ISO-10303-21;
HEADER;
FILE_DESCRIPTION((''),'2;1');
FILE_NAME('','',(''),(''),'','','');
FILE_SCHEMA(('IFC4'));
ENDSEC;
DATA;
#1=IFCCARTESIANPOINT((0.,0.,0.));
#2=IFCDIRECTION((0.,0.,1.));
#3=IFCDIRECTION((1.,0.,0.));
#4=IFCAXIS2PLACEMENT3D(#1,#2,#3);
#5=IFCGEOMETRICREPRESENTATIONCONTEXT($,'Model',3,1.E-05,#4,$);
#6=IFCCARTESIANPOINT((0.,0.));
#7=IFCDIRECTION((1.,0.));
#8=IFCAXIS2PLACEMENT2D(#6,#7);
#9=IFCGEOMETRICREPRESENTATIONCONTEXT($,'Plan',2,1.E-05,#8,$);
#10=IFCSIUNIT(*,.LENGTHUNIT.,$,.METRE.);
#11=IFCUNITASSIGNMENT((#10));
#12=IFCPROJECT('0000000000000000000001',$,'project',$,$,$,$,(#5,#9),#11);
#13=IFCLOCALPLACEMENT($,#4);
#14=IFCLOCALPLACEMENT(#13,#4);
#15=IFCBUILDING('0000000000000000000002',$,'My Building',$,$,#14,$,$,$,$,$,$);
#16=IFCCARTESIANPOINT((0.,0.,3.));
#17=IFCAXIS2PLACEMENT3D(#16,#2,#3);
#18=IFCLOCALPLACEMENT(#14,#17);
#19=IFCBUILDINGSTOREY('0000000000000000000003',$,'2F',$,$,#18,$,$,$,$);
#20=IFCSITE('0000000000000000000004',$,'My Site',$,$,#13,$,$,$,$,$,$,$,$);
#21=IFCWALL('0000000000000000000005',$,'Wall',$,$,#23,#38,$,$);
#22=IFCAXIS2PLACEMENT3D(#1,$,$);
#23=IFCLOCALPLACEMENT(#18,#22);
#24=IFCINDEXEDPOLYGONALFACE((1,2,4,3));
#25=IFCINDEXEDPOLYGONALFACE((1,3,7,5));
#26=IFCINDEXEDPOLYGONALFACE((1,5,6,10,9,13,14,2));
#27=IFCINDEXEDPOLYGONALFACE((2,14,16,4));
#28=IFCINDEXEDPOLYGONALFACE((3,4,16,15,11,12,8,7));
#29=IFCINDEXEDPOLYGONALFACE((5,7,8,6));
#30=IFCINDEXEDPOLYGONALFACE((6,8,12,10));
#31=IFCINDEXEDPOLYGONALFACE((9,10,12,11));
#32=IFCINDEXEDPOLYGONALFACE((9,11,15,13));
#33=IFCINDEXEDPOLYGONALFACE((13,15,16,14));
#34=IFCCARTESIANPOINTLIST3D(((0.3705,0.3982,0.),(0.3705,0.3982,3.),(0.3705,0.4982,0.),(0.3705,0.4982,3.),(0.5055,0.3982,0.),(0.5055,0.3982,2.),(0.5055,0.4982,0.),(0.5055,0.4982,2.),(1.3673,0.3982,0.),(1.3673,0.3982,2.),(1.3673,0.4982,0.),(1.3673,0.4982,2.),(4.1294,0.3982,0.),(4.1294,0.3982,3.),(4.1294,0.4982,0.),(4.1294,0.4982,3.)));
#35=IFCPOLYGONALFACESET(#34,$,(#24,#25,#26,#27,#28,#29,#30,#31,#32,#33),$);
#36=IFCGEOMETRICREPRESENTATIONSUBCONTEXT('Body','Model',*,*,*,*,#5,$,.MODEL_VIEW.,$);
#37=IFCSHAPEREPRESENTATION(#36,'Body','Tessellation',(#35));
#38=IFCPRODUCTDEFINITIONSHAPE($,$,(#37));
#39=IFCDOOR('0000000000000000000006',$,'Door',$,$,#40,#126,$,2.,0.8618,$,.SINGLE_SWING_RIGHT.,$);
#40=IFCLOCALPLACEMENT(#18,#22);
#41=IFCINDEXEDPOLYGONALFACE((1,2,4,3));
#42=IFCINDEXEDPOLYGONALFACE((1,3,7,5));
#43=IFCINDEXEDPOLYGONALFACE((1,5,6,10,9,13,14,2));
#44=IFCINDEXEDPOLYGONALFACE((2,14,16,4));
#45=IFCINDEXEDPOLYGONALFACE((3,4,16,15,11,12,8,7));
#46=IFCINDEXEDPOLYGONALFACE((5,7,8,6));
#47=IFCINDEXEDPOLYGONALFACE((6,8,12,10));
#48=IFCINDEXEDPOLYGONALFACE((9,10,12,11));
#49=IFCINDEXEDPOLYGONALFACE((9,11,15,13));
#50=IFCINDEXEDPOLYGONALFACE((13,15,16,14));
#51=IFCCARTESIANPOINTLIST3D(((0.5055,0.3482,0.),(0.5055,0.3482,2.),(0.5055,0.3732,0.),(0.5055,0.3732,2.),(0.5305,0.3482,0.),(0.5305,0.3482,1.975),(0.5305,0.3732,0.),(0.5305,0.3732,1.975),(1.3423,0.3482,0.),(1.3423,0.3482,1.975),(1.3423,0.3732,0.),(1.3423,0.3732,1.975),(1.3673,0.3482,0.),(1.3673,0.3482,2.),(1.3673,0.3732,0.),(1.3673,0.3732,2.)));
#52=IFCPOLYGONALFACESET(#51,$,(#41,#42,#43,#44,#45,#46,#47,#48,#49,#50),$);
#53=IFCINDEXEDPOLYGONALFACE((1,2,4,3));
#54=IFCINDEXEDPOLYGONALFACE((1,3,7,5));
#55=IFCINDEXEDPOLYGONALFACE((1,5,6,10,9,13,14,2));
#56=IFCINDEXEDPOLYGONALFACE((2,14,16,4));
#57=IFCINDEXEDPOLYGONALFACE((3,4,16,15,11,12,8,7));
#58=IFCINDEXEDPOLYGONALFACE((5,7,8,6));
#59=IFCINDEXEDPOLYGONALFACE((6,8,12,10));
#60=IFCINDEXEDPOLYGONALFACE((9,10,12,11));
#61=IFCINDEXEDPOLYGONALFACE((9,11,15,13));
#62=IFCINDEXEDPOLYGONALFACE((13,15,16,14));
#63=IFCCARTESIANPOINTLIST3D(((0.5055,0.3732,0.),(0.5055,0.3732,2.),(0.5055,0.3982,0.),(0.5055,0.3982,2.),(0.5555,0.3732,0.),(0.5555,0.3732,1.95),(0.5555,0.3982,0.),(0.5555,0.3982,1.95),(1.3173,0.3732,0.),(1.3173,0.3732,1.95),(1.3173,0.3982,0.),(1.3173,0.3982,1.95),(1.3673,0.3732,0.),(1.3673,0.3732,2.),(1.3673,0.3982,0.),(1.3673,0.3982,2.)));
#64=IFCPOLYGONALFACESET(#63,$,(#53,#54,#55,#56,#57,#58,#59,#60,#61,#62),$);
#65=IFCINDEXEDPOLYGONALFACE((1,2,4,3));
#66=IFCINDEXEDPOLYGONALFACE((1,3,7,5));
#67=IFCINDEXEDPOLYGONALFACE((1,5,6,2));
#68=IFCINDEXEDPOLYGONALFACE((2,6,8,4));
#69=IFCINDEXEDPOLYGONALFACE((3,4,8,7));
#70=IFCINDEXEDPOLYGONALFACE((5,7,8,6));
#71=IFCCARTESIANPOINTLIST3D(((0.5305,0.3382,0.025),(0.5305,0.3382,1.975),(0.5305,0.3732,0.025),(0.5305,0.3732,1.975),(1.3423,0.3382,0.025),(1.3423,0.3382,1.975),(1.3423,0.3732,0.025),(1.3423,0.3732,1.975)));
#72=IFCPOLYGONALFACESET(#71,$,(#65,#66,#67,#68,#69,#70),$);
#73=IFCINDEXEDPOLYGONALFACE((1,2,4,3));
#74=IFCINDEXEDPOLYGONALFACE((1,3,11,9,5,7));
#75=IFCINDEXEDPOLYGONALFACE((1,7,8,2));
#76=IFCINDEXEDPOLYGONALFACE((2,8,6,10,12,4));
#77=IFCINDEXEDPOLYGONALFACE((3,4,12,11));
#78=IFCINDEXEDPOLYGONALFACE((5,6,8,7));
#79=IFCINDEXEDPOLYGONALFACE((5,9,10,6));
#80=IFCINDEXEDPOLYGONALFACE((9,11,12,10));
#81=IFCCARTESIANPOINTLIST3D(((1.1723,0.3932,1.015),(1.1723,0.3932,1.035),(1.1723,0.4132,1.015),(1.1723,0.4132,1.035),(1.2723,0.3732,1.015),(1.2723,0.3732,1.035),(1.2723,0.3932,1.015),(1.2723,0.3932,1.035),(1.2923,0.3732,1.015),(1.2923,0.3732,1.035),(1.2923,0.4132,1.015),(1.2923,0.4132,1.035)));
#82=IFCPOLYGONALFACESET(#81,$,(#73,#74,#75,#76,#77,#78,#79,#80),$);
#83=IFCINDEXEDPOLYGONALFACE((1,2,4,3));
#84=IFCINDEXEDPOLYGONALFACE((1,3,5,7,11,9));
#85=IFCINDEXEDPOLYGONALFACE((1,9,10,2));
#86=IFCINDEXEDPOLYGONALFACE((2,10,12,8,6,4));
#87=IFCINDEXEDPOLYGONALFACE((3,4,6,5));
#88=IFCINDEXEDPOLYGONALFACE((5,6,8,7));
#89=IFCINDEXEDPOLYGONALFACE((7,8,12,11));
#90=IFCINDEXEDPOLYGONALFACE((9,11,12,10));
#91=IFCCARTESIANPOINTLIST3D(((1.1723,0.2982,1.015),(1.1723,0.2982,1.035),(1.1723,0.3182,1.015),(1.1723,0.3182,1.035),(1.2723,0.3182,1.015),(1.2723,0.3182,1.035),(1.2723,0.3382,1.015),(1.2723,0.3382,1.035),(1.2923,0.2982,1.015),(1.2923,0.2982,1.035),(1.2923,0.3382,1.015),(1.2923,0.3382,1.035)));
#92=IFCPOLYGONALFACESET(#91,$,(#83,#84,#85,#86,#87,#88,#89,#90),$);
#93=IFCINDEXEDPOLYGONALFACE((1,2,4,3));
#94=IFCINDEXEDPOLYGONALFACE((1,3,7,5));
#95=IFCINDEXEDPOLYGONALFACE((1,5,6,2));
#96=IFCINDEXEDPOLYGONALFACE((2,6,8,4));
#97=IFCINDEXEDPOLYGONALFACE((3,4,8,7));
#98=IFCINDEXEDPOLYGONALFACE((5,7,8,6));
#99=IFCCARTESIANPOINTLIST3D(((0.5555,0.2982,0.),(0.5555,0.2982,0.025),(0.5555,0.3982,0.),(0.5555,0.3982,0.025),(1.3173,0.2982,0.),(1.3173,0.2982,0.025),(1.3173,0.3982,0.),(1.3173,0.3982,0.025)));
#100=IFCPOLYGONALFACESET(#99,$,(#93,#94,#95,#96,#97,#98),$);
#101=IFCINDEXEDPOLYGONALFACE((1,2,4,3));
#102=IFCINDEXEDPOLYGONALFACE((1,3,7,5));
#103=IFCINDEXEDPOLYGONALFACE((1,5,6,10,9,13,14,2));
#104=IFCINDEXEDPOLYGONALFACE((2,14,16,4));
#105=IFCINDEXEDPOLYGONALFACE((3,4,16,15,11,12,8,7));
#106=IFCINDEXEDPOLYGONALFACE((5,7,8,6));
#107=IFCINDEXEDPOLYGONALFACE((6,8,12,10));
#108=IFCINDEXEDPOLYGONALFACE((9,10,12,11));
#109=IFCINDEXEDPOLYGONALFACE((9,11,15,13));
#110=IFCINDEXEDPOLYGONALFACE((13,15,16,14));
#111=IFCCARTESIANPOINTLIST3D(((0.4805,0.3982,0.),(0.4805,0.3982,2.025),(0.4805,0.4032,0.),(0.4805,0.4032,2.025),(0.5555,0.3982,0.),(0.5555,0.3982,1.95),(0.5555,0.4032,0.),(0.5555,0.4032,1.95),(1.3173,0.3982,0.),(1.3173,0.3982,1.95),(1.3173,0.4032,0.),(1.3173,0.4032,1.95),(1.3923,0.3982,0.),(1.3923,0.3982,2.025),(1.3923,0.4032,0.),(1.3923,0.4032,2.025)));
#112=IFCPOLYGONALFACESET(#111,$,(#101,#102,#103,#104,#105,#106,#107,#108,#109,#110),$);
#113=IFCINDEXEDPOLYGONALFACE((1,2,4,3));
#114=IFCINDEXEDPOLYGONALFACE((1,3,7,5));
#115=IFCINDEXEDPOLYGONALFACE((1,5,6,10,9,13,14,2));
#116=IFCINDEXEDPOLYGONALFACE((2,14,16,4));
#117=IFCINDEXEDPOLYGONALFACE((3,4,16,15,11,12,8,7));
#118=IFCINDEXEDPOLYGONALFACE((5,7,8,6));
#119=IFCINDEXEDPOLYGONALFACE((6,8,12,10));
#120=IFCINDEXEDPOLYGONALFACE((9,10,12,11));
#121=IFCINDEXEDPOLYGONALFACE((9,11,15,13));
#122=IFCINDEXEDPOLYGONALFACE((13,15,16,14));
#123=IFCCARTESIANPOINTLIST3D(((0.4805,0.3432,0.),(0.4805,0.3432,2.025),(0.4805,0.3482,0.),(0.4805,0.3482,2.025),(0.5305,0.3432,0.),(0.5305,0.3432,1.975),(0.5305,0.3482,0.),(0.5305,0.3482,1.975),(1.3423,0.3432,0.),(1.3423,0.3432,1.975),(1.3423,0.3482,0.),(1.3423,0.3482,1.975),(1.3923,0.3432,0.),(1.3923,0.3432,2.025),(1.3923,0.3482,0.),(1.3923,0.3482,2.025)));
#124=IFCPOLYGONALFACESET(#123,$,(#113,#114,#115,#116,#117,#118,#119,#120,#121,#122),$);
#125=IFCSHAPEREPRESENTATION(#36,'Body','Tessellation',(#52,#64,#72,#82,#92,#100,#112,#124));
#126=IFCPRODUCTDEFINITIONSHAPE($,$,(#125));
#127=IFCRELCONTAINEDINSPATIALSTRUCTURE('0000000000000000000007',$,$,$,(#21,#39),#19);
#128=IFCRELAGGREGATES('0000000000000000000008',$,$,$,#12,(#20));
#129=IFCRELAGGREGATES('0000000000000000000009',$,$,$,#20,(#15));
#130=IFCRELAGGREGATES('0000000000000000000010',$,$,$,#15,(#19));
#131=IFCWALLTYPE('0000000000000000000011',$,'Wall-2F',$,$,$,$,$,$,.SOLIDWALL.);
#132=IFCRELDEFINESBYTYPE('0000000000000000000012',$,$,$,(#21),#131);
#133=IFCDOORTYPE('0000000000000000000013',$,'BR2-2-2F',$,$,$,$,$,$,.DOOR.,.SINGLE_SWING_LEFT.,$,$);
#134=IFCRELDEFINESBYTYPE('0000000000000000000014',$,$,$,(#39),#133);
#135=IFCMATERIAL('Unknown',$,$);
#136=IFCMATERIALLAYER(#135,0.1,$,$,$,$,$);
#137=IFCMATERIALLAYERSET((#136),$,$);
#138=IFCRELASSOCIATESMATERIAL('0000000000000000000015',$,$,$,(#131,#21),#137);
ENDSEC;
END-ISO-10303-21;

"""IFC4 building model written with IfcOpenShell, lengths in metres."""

from ifc_helpers import new_model, entity, si_unit, frame, origin_with_axes, origin_2d_with_axis, place, context, subcontext, project, spatial, line, indexed_curve, outline, extrude, shape, source, transform, mapped, material, layer, layer_set, layer_usage, type_object, type_shapes, element, fill, save


model = new_model("IFC4")

# Units and contexts
model_context = context("Model", 3, precision=1e-05, world=origin_with_axes())
plan_context = context("Plan", 2, precision=1e-05, world=origin_2d_with_axis())
body_context_1 = subcontext(model_context, "Body", "Model", "MODEL_VIEW")
body_context_2 = subcontext(plan_context, "Body", "Plan", "PLAN_VIEW")
ifc_project = project(units=[si_unit("LENGTHUNIT", "METRE")], contexts=[model_context, plan_context])

# Site, building, storey
site_placement = place(None, origin_with_axes())
site = spatial("IfcSite", under=ifc_project, at=site_placement, Name="My Site")
building_placement = place(site_placement, origin_with_axes())
building = spatial("IfcBuilding", under=site, at=building_placement, Name="My Building")
storey_placement = place(building_placement, frame((0.0, 0.0, 3.0), z_axis=(0.0, 0.0, 1.0), x_axis=(1.0, 0.0, 0.0)))
storey = spatial("IfcBuildingStorey", under=building, at=storey_placement, Name="2F")

# Shared definitions
ifc_material = material(Name="Unknown")

# Shared definitions
ifc_layer = layer(ifc_material, 0.1)
ifc_layer_set = layer_set([ifc_layer])
wall_type = type_object("IfcWallType", Name="Wall-2F", PredefinedType="SOLIDWALL", material=ifc_layer_set)

# Wall, opening, door
ifc_layer_usage_1 = layer_usage(ifc_layer_set, "AXIS2", "NEGATIVE", 0.0)
wall_1_placement = place(storey_placement, frame((0.3705, 0.4982, 0.0), z_axis=(0.0, 0.0, 1.0), x_axis=(1.0, 0.0, 0.0)))
wall_1 = element("IfcWall", 1, at=wall_1_placement, inside=storey, type_object=wall_type, material=ifc_layer_usage_1, Name="Wall", context=body_context_1, shape_type="SweptSolid", body=[
    extrude(outline(indexed_curve([(0.0, -0.1), (0.0, 0.0), (3.7589, 0.0), (3.7589, -0.1)], segments=[line(1, 2, 3, 4, 1)])), origin_with_axes(), (0.0, 0.0, 1.0), 3.0),
])
shared_shape_1 = source(origin_with_axes(), body_context_1, "Body", "SweptSolid", [
    extrude(outline(indexed_curve([(0.0, 0.0), (0.8618, 0.0), (0.8618, 2.0), (0.0, 2.0)], segments=[line(1, 2, 3, 4, 1)])), frame((0.0, -0.6, 0.0), z_axis=(0.0, -1.0, 0.0), x_axis=(1.0, 0.0, 0.0)), (0.0, 0.0, -1.0), 1.2),
])
opening_1_placement = place(wall_1_placement, frame((0.9968, -0.1, 0.0), z_axis=(0.0, 0.0, 1.0), x_axis=(-1.0, 0.0, 0.0)))
opening_1 = element("IfcOpeningElement", 2, at=opening_1_placement, cuts=wall_1, PredefinedType="OPENING", context=body_context_1, shape_type="MappedRepresentation", body=[
    mapped(shared_shape_1, transform((0.0, 0.0, 0.0), x_axis=(1.0, 0.0, 0.0), y_axis=(0.0, 1.0, 0.0), z_axis=(0.0, 0.0, 1.0), scale=1.0)),
])
door_type_1 = type_object("IfcDoorType", Name="BR2-2-2F", OperationType="SINGLE_SWING_LEFT", PredefinedType="DOOR")
shared_shape_2 = source(origin_with_axes(), body_context_1, "Body", "SweptSolid", [
    extrude(outline(indexed_curve([(0.0, 0.0), (0.0, 2.0), (0.8618, 2.0), (0.8618, 0.0), (0.8368, 0.0), (0.8368, 1.975), (0.025, 1.975), (0.025, 0.0)], segments=[line(1, 2, 3, 4, 5, 6, 7, 8, 1)])), frame((0.0, 0.025, 0.0), z_axis=(0.0, -1.0, 0.0), x_axis=(1.0, 0.0, 0.0)), (0.0, 0.0, -1.0), 0.025),
    extrude(outline(indexed_curve([(0.0, 0.0), (0.0, 2.0), (0.8618, 2.0), (0.8618, 0.0), (0.8118, 0.0), (0.8118, 1.95), (0.05, 1.95), (0.05, 0.0)], segments=[line(1, 2, 3, 4, 5, 6, 7, 8, 1)])), frame((0.0, 0.0, 0.0), z_axis=(0.0, -1.0, 0.0), x_axis=(1.0, 0.0, 0.0)), (0.0, 0.0, -1.0), 0.025),
    extrude(outline(indexed_curve([(0.0, 0.0), (0.8118, 0.0), (0.8118, 0.035), (0.0, 0.035)], segments=[line(1, 2, 3, 4, 1)])), frame((0.025, 0.025, 0.025), z_axis=(0.0, 0.0, 1.0), x_axis=(1.0, 0.0, 0.0)), (0.0, 0.0, 1.0), 1.95),
    extrude(outline(indexed_curve([(0.0, 0.0), (0.0, -0.04), (0.12, -0.04), (0.12, -0.02), (0.02, -0.02), (0.02, 0.0)], segments=[line(1, 2, 3, 4, 5, 6, 1)])), frame((0.075, 0.025, 1.015), z_axis=(0.0, 0.0, 1.0), x_axis=(1.0, 0.0, 0.0)), (0.0, 0.0, 1.0), 0.02),
    extrude(outline(indexed_curve([(0.0, 0.0), (0.0, 0.04), (0.12, 0.04), (0.12, 0.02), (0.02, 0.02), (0.02, 0.0)], segments=[line(1, 2, 3, 4, 5, 6, 1)])), frame((0.075, 0.06, 1.015), z_axis=(0.0, 0.0, 1.0), x_axis=(1.0, 0.0, 0.0)), (0.0, 0.0, 1.0), 0.02),
    extrude(outline(indexed_curve([(0.0, 0.0), (0.7618, 0.0), (0.7618, 0.1), (0.0, 0.1)], segments=[line(1, 2, 3, 4, 1)])), frame((0.05, 0.0, 0.0), z_axis=(0.0, 0.0, 1.0), x_axis=(1.0, 0.0, 0.0)), (0.0, 0.0, 1.0), 0.025),
    extrude(outline(indexed_curve([(0.0, 0.0), (0.0, 2.025), (0.9118, 2.025), (0.9118, 0.0), (0.8368, 0.0), (0.8368, 1.95), (0.075, 1.95), (0.075, 0.0)], segments=[line(1, 2, 3, 4, 5, 6, 7, 8, 1)])), frame((-0.025, -0.005, 0.0), z_axis=(0.0, -1.0, 0.0), x_axis=(1.0, 0.0, 0.0)), (0.0, 0.0, -1.0), 0.005),
    extrude(outline(indexed_curve([(0.0, 0.0), (0.0, 2.025), (0.9118, 2.025), (0.9118, 0.0), (0.8618, 0.0), (0.8618, 1.975), (0.05, 1.975), (0.05, 0.0)], segments=[line(1, 2, 3, 4, 5, 6, 7, 8, 1)])), frame((-0.025, 0.05, 0.0), z_axis=(0.0, -1.0, 0.0), x_axis=(1.0, 0.0, 0.0)), (0.0, 0.0, -1.0), 0.005),
])
shared_shape_3 = source(origin_with_axes(), body_context_2, "Body", "Curve2D", [
    entity("IfcIndexedPolyCurve", entity("IfcCartesianPointList2D", [[0.0, 0.0], [0.0, 0.05], [0.025, 0.05], [0.025, 0.025], [0.05, 0.025], [0.05, 0.0]]), [entity("IfcLineIndex", [1, 2, 3, 4, 5, 6, 1])]),
    entity("IfcIndexedPolyCurve", entity("IfcCartesianPointList2D", [[0.8618, 0.0], [0.8618, 0.05], [0.8368, 0.05], [0.8368, 0.025], [0.8118, 0.025], [0.8118, 0.0]]), [entity("IfcLineIndex", [1, 2, 3, 4, 5, 6, 1])]),
    entity("IfcTrimmedCurve", entity("IfcEllipse", entity("IfcAxis2Placement2D", entity("IfcCartesianPoint", [0.8018, 0.05]), entity("IfcDirection", [1.0, 0.0])), 0.7768, 0.8118), [entity("IfcCartesianPoint", [0.8018, 0.8618])], [entity("IfcCartesianPoint", [0.025, 0.05])], True, "CARTESIAN"),
    entity("IfcIndexedPolyCurve", entity("IfcCartesianPointList2D", [[0.8368, 0.05], [0.8018, 0.05], [0.8018, 0.8618], [0.8368, 0.8618]]), [entity("IfcLineIndex", [1, 2, 3, 4, 1])]),
])
type_shapes(door_type_1, [shared_shape_2, shared_shape_3])
door_1_placement = place(opening_1_placement, frame((0.0, 0.0, 0.0), z_axis=(0.0, 0.0, 1.0), x_axis=(1.0, 0.0, 0.0)))
door_1 = element("IfcDoor", 3, at=door_1_placement, inside=storey, type_object=door_type_1, Name="Door", OperationType="SINGLE_SWING_RIGHT", OverallHeight=2.0, OverallWidth=0.8618, shapes=[
    shape(body_context_1, "Body", "MappedRepresentation", [mapped(shared_shape_2, transform((0.0, 0.0, 0.0), x_axis=(1.0, 0.0, 0.0), y_axis=(0.0, 1.0, 0.0), z_axis=(0.0, 0.0, 1.0), scale=1.0))]),
    shape(body_context_2, "Body", "MappedRepresentation", [mapped(shared_shape_3, transform((0.0, 0.0, 0.0), x_axis=(1.0, 0.0, 0.0), y_axis=(0.0, 1.0, 0.0), z_axis=(0.0, 0.0, 1.0), scale=1.0))]),
])
fill(opening_1, door_1)

save(model, "model.ifc")
